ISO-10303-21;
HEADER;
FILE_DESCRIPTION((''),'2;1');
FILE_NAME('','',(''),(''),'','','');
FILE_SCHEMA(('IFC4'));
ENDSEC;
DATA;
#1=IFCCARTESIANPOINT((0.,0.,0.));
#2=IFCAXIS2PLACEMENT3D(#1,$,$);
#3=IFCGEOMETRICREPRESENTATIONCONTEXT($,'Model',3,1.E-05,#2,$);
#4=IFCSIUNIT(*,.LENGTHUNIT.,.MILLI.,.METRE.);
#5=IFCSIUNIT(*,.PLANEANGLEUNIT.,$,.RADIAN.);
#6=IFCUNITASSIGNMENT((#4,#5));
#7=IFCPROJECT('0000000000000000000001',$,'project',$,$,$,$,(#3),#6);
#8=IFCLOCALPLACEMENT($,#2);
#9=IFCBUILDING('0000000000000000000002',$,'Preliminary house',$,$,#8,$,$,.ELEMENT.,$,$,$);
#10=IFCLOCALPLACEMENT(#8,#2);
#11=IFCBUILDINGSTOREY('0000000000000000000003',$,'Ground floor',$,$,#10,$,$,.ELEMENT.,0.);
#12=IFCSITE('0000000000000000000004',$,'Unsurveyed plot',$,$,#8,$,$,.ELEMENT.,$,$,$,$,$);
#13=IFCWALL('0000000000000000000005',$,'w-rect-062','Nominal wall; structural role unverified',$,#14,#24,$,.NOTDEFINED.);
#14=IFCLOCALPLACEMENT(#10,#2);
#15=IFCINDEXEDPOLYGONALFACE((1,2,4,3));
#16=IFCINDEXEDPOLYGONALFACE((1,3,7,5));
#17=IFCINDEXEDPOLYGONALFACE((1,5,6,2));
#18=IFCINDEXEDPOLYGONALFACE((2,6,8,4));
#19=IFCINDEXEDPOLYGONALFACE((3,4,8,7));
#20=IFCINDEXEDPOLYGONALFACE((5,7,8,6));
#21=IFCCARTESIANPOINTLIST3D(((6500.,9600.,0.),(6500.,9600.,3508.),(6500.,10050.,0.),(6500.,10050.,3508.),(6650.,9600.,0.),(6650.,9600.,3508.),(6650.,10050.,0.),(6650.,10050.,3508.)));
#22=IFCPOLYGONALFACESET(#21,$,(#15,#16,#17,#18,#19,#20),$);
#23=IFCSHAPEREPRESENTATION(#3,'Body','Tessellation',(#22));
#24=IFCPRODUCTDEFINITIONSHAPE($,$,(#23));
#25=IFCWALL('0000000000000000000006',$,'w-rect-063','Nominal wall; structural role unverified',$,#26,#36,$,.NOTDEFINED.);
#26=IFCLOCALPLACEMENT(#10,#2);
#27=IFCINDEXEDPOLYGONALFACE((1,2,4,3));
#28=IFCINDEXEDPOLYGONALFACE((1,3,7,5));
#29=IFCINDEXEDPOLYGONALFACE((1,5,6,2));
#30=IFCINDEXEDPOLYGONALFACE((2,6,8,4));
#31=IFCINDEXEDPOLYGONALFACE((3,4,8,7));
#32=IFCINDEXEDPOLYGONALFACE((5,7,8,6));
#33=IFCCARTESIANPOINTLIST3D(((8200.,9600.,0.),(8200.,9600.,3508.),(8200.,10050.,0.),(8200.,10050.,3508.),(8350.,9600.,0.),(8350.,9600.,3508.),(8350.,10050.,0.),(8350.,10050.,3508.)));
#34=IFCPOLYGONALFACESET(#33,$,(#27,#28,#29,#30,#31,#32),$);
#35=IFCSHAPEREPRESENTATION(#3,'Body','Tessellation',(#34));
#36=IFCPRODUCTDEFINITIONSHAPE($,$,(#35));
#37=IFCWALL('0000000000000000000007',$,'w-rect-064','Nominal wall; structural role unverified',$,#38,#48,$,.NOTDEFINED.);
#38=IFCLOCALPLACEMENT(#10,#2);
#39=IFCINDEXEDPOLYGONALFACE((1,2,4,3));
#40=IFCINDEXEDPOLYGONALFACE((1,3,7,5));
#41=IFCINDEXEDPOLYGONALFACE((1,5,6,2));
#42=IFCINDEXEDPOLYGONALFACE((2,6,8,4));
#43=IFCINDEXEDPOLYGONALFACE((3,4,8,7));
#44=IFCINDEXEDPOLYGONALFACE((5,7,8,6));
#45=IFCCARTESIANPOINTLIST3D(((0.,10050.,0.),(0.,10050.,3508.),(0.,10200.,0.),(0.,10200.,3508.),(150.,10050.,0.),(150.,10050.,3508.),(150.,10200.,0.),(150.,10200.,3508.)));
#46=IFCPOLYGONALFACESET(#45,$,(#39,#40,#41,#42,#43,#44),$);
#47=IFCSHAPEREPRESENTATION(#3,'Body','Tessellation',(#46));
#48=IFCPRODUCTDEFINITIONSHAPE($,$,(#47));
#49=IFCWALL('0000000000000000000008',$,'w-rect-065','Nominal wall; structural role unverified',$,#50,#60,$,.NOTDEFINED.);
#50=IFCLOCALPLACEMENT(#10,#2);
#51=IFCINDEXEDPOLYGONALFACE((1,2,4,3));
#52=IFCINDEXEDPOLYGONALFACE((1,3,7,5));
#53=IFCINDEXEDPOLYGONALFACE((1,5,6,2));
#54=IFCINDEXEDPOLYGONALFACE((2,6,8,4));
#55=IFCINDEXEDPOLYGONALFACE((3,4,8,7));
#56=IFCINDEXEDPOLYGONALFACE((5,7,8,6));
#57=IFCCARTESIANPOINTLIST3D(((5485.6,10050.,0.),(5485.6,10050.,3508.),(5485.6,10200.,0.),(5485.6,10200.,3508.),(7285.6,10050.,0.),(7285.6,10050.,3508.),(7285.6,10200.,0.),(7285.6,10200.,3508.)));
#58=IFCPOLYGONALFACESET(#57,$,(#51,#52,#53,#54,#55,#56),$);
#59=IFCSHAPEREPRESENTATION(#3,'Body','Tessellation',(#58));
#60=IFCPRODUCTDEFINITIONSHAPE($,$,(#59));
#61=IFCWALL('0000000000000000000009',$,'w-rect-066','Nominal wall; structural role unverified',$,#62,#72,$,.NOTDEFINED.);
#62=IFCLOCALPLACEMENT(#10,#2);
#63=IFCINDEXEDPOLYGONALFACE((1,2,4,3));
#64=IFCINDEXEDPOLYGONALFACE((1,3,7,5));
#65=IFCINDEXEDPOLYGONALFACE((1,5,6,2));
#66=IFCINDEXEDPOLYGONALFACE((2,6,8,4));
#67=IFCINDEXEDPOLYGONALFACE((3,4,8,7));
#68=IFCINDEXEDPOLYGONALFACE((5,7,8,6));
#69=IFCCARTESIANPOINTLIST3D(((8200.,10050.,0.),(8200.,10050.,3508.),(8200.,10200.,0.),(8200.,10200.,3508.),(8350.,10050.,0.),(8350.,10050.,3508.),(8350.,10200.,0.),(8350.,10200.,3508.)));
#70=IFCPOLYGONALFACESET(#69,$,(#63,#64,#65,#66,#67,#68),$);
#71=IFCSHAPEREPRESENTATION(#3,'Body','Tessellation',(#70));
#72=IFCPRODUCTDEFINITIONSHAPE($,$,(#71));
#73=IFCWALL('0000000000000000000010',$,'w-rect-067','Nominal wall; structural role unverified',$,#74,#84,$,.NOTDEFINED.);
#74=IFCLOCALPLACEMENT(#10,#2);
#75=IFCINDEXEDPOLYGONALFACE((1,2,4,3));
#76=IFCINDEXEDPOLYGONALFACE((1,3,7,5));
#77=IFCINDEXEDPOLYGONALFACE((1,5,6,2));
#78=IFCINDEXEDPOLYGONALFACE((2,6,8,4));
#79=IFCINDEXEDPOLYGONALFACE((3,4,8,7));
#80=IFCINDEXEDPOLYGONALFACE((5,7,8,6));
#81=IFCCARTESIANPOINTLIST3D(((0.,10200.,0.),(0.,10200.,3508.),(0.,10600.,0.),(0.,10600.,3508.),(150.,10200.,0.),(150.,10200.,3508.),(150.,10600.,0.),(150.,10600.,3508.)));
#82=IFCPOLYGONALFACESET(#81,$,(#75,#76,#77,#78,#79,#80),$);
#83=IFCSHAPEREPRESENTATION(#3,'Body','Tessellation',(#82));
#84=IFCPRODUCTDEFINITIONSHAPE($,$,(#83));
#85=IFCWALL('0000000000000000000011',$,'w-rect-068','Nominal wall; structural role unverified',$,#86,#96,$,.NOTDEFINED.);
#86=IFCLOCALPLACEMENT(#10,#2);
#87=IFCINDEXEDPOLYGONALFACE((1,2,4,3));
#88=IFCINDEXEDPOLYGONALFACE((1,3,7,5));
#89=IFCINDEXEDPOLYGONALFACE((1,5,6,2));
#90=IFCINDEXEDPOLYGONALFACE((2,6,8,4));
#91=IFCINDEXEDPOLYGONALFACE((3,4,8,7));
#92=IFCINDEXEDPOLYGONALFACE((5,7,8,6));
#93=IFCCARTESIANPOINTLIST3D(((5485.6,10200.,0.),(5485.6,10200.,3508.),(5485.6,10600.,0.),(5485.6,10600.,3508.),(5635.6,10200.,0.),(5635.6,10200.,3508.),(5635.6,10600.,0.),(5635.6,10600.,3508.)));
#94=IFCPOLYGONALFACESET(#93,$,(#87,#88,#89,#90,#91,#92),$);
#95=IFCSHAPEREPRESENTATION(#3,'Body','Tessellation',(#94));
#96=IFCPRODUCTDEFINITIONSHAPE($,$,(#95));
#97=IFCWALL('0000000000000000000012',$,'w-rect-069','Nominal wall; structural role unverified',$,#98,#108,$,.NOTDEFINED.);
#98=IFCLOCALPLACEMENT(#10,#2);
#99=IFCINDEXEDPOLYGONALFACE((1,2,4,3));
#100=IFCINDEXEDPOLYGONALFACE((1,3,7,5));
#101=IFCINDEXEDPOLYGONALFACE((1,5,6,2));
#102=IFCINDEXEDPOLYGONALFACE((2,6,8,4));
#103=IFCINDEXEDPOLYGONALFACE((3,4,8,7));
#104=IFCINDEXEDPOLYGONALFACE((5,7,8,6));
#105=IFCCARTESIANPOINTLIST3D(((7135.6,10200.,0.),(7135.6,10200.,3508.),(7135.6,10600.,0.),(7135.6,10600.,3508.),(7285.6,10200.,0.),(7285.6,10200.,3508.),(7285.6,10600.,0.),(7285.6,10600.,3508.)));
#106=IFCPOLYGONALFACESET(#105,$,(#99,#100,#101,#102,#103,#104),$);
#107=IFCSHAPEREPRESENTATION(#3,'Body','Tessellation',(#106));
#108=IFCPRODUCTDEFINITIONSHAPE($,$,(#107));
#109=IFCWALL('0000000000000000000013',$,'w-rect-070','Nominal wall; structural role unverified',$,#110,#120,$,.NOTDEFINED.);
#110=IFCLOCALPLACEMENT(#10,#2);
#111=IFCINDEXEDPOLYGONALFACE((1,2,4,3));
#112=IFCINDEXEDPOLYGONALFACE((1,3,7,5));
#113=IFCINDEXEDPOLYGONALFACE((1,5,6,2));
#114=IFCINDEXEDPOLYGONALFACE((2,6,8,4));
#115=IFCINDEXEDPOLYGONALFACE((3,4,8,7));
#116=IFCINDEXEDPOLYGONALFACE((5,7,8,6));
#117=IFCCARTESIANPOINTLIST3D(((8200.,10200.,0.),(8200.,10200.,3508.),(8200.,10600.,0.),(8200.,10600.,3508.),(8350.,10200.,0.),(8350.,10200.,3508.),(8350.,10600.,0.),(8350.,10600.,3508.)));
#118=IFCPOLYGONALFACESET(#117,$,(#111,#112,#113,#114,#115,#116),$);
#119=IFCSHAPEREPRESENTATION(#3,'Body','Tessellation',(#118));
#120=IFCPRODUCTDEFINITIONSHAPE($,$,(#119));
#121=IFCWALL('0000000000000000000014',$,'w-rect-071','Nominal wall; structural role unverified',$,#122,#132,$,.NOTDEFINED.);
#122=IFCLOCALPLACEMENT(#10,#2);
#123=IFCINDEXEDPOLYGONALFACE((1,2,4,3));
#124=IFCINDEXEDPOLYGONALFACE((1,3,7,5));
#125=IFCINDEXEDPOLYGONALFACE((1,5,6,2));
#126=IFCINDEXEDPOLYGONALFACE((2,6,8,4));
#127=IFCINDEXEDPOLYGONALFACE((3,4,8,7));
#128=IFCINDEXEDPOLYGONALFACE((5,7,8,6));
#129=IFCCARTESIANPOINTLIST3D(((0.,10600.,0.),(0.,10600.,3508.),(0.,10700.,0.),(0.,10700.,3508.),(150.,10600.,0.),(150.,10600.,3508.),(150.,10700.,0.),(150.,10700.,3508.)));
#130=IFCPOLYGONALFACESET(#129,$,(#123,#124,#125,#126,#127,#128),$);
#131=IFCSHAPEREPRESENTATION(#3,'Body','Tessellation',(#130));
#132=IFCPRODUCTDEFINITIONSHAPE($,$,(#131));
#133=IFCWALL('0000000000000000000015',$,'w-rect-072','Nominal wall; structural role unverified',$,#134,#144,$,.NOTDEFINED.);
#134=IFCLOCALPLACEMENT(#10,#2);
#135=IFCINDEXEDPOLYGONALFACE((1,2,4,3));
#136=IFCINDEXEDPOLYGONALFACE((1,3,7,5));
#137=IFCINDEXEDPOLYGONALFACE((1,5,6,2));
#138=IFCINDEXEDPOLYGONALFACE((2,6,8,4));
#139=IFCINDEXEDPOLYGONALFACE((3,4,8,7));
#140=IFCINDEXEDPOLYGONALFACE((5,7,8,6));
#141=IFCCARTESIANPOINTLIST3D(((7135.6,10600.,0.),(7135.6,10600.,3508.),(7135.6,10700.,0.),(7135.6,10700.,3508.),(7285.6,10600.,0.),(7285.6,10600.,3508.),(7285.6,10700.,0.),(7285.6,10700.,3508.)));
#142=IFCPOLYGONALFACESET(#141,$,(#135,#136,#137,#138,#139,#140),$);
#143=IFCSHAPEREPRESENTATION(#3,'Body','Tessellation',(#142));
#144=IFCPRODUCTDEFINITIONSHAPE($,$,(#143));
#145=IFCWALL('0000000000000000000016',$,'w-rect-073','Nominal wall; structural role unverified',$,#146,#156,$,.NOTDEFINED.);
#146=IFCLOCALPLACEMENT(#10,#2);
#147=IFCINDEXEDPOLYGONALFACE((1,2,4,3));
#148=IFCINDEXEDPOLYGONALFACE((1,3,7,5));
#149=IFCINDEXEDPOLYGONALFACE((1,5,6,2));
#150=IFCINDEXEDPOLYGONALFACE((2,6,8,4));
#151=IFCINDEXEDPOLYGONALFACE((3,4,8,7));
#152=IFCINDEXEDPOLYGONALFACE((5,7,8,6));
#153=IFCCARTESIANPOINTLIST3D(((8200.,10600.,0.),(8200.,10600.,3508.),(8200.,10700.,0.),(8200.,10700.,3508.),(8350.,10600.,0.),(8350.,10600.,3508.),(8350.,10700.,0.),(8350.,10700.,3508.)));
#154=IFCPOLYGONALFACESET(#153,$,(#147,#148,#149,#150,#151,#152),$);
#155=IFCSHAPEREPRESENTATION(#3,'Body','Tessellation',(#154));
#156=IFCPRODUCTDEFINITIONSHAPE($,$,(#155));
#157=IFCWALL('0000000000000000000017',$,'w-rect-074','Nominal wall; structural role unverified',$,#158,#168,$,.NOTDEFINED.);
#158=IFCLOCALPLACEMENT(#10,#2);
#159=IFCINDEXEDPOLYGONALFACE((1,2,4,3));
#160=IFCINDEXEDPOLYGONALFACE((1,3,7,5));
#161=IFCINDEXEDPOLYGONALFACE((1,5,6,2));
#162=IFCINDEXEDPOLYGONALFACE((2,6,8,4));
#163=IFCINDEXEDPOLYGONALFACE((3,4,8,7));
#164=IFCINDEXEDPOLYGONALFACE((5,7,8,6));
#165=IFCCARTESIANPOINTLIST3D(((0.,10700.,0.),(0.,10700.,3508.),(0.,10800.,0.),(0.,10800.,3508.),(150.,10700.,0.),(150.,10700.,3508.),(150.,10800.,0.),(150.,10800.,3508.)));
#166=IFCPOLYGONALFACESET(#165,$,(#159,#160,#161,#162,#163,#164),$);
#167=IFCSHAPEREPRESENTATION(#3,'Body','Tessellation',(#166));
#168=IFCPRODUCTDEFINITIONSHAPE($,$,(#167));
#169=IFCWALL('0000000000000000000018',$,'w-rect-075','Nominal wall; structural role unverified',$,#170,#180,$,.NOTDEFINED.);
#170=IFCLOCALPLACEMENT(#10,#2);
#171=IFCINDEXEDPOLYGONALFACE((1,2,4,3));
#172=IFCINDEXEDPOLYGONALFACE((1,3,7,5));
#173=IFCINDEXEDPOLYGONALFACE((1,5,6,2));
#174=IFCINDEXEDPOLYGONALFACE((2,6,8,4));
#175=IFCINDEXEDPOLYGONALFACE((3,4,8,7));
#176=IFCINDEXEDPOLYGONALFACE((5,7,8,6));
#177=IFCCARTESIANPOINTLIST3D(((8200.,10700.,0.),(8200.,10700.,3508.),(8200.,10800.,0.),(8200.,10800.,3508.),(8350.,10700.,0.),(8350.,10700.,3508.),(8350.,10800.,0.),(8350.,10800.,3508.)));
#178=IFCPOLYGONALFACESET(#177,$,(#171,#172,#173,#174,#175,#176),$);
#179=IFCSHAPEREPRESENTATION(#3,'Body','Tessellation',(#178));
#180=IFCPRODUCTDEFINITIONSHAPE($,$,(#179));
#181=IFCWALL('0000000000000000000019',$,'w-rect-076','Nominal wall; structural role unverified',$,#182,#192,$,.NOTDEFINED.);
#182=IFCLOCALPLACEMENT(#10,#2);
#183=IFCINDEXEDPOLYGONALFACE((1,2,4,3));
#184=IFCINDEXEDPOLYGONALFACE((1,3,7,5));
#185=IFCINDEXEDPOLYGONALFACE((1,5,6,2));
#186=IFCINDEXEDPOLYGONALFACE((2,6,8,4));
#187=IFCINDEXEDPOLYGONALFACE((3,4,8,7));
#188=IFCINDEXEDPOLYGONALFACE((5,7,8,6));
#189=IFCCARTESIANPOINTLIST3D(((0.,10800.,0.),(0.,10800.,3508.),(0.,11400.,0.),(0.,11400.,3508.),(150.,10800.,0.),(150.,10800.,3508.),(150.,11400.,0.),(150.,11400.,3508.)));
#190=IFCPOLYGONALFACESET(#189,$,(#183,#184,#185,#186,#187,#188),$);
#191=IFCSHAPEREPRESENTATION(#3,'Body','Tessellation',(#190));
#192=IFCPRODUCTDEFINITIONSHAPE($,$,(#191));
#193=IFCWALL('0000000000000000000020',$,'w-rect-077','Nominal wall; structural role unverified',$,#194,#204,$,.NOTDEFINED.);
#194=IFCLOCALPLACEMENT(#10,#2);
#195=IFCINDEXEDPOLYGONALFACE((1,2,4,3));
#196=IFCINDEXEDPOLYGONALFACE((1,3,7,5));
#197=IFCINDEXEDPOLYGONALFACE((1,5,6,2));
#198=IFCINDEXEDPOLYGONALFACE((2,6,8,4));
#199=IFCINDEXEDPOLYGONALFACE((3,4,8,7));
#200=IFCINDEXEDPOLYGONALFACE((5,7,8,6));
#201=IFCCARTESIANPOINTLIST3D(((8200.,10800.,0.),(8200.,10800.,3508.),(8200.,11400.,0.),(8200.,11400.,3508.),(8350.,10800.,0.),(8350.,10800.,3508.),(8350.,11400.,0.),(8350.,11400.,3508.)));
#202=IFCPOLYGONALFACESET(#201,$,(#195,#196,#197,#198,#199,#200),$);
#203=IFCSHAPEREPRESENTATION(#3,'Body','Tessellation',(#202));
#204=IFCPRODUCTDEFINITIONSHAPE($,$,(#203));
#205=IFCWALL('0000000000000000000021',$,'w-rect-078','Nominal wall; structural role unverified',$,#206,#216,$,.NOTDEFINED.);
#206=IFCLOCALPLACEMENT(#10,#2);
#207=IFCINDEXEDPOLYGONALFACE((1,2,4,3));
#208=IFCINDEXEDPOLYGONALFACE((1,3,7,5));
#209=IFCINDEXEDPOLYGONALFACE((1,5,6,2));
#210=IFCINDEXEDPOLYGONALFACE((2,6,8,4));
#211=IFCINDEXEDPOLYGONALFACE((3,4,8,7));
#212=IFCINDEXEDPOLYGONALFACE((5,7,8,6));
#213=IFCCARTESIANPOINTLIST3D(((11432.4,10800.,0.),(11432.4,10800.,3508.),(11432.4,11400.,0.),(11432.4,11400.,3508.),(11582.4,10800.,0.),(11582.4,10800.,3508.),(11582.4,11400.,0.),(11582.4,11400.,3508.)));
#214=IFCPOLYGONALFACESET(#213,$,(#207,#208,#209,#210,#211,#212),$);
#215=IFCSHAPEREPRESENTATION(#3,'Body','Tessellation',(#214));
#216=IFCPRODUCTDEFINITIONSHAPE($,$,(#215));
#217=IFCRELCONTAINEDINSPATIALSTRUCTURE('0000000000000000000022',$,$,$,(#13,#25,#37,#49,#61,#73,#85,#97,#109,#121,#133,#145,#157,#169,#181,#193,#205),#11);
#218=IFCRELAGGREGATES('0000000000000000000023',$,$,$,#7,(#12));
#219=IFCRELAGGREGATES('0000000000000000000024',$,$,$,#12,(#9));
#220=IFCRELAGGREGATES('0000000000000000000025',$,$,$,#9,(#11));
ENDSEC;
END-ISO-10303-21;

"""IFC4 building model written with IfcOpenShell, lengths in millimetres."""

from ifc_helpers import new_model, si_unit, origin, place, context, project, spatial, polyline, outline, extrude, element, save


model = new_model("IFC4")

# Units and contexts
model_context = context("Model", 3, precision=1e-05, world=origin())
ifc_project = project(units=[si_unit("LENGTHUNIT", "METRE", prefix="MILLI"), si_unit("PLANEANGLEUNIT", "RADIAN")], contexts=[model_context])

# Site, building, storey
placement_1 = place(None, origin())
site = spatial("IfcSite", under=ifc_project, at=placement_1, Name="Unsurveyed plot", CompositionType="ELEMENT")
building = spatial("IfcBuilding", under=site, at=placement_1, Name="Preliminary house", CompositionType="ELEMENT")
placement_2 = place(placement_1, origin())
storey = spatial("IfcBuildingStorey", under=building, at=placement_2, Name="Ground floor", CompositionType="ELEMENT", Elevation=0.0)

# Walls
element("IfcWall", 1, at=placement_2, inside=storey, Name="w-rect-062", Description="Nominal wall; structural role unverified", PredefinedType="NOTDEFINED", context=model_context, shape_type="SweptSolid", body=[
    extrude(outline(polyline([(6500.0, 9600.0), (6650.0, 9600.0), (6650.0, 10050.0), (6500.0, 10050.0), (6500.0, 9600.0)])), origin(), (0.0, 0.0, 1.0), 3508.0),
])
element("IfcWall", 2, at=placement_2, inside=storey, Name="w-rect-063", Description="Nominal wall; structural role unverified", PredefinedType="NOTDEFINED", context=model_context, shape_type="SweptSolid", body=[
    extrude(outline(polyline([(8200.0, 9600.0), (8350.0, 9600.0), (8350.0, 10050.0), (8200.0, 10050.0), (8200.0, 9600.0)])), origin(), (0.0, 0.0, 1.0), 3508.0),
])
element("IfcWall", 3, at=placement_2, inside=storey, Name="w-rect-064", Description="Nominal wall; structural role unverified", PredefinedType="NOTDEFINED", context=model_context, shape_type="SweptSolid", body=[
    extrude(outline(polyline([(0.0, 10050.0), (150.0, 10050.0), (150.0, 10200.0), (0.0, 10200.0), (0.0, 10050.0)])), origin(), (0.0, 0.0, 1.0), 3508.0),
])
element("IfcWall", 4, at=placement_2, inside=storey, Name="w-rect-065", Description="Nominal wall; structural role unverified", PredefinedType="NOTDEFINED", context=model_context, shape_type="SweptSolid", body=[
    extrude(outline(polyline([(5485.6, 10050.0), (7285.6, 10050.0), (7285.6, 10200.0), (5485.6, 10200.0), (5485.6, 10050.0)])), origin(), (0.0, 0.0, 1.0), 3508.0),
])
element("IfcWall", 5, at=placement_2, inside=storey, Name="w-rect-066", Description="Nominal wall; structural role unverified", PredefinedType="NOTDEFINED", context=model_context, shape_type="SweptSolid", body=[
    extrude(outline(polyline([(8200.0, 10050.0), (8350.0, 10050.0), (8350.0, 10200.0), (8200.0, 10200.0), (8200.0, 10050.0)])), origin(), (0.0, 0.0, 1.0), 3508.0),
])
element("IfcWall", 6, at=placement_2, inside=storey, Name="w-rect-067", Description="Nominal wall; structural role unverified", PredefinedType="NOTDEFINED", context=model_context, shape_type="SweptSolid", body=[
    extrude(outline(polyline([(0.0, 10200.0), (150.0, 10200.0), (150.0, 10600.0), (0.0, 10600.0), (0.0, 10200.0)])), origin(), (0.0, 0.0, 1.0), 3508.0),
])
element("IfcWall", 7, at=placement_2, inside=storey, Name="w-rect-068", Description="Nominal wall; structural role unverified", PredefinedType="NOTDEFINED", context=model_context, shape_type="SweptSolid", body=[
    extrude(outline(polyline([(5485.6, 10200.0), (5635.6, 10200.0), (5635.6, 10600.0), (5485.6, 10600.0), (5485.6, 10200.0)])), origin(), (0.0, 0.0, 1.0), 3508.0),
])
element("IfcWall", 8, at=placement_2, inside=storey, Name="w-rect-069", Description="Nominal wall; structural role unverified", PredefinedType="NOTDEFINED", context=model_context, shape_type="SweptSolid", body=[
    extrude(outline(polyline([(7135.6, 10200.0), (7285.6, 10200.0), (7285.6, 10600.0), (7135.6, 10600.0), (7135.6, 10200.0)])), origin(), (0.0, 0.0, 1.0), 3508.0),
])
element("IfcWall", 9, at=placement_2, inside=storey, Name="w-rect-070", Description="Nominal wall; structural role unverified", PredefinedType="NOTDEFINED", context=model_context, shape_type="SweptSolid", body=[
    extrude(outline(polyline([(8200.0, 10200.0), (8350.0, 10200.0), (8350.0, 10600.0), (8200.0, 10600.0), (8200.0, 10200.0)])), origin(), (0.0, 0.0, 1.0), 3508.0),
])
element("IfcWall", 10, at=placement_2, inside=storey, Name="w-rect-071", Description="Nominal wall; structural role unverified", PredefinedType="NOTDEFINED", context=model_context, shape_type="SweptSolid", body=[
    extrude(outline(polyline([(0.0, 10600.0), (150.0, 10600.0), (150.0, 10700.0), (0.0, 10700.0), (0.0, 10600.0)])), origin(), (0.0, 0.0, 1.0), 3508.0),
])
element("IfcWall", 11, at=placement_2, inside=storey, Name="w-rect-072", Description="Nominal wall; structural role unverified", PredefinedType="NOTDEFINED", context=model_context, shape_type="SweptSolid", body=[
    extrude(outline(polyline([(7135.6, 10600.0), (7285.6, 10600.0), (7285.6, 10700.0), (7135.6, 10700.0), (7135.6, 10600.0)])), origin(), (0.0, 0.0, 1.0), 3508.0),
])
element("IfcWall", 12, at=placement_2, inside=storey, Name="w-rect-073", Description="Nominal wall; structural role unverified", PredefinedType="NOTDEFINED", context=model_context, shape_type="SweptSolid", body=[
    extrude(outline(polyline([(8200.0, 10600.0), (8350.0, 10600.0), (8350.0, 10700.0), (8200.0, 10700.0), (8200.0, 10600.0)])), origin(), (0.0, 0.0, 1.0), 3508.0),
])
element("IfcWall", 13, at=placement_2, inside=storey, Name="w-rect-074", Description="Nominal wall; structural role unverified", PredefinedType="NOTDEFINED", context=model_context, shape_type="SweptSolid", body=[
    extrude(outline(polyline([(0.0, 10700.0), (150.0, 10700.0), (150.0, 10800.0), (0.0, 10800.0), (0.0, 10700.0)])), origin(), (0.0, 0.0, 1.0), 3508.0),
])
element("IfcWall", 14, at=placement_2, inside=storey, Name="w-rect-075", Description="Nominal wall; structural role unverified", PredefinedType="NOTDEFINED", context=model_context, shape_type="SweptSolid", body=[
    extrude(outline(polyline([(8200.0, 10700.0), (8350.0, 10700.0), (8350.0, 10800.0), (8200.0, 10800.0), (8200.0, 10700.0)])), origin(), (0.0, 0.0, 1.0), 3508.0),
])
element("IfcWall", 15, at=placement_2, inside=storey, Name="w-rect-076", Description="Nominal wall; structural role unverified", PredefinedType="NOTDEFINED", context=model_context, shape_type="SweptSolid", body=[
    extrude(outline(polyline([(0.0, 10800.0), (150.0, 10800.0), (150.0, 11400.0), (0.0, 11400.0), (0.0, 10800.0)])), origin(), (0.0, 0.0, 1.0), 3508.0),
])
element("IfcWall", 16, at=placement_2, inside=storey, Name="w-rect-077", Description="Nominal wall; structural role unverified", PredefinedType="NOTDEFINED", context=model_context, shape_type="SweptSolid", body=[
    extrude(outline(polyline([(8200.0, 10800.0), (8350.0, 10800.0), (8350.0, 11400.0), (8200.0, 11400.0), (8200.0, 10800.0)])), origin(), (0.0, 0.0, 1.0), 3508.0),
])
element("IfcWall", 17, at=placement_2, inside=storey, Name="w-rect-078", Description="Nominal wall; structural role unverified", PredefinedType="NOTDEFINED", context=model_context, shape_type="SweptSolid", body=[
    extrude(outline(polyline([(11432.4, 10800.0), (11582.4, 10800.0), (11582.4, 11400.0), (11432.4, 11400.0), (11432.4, 10800.0)])), origin(), (0.0, 0.0, 1.0), 3508.0),
])

save(model, "model.ifc")
